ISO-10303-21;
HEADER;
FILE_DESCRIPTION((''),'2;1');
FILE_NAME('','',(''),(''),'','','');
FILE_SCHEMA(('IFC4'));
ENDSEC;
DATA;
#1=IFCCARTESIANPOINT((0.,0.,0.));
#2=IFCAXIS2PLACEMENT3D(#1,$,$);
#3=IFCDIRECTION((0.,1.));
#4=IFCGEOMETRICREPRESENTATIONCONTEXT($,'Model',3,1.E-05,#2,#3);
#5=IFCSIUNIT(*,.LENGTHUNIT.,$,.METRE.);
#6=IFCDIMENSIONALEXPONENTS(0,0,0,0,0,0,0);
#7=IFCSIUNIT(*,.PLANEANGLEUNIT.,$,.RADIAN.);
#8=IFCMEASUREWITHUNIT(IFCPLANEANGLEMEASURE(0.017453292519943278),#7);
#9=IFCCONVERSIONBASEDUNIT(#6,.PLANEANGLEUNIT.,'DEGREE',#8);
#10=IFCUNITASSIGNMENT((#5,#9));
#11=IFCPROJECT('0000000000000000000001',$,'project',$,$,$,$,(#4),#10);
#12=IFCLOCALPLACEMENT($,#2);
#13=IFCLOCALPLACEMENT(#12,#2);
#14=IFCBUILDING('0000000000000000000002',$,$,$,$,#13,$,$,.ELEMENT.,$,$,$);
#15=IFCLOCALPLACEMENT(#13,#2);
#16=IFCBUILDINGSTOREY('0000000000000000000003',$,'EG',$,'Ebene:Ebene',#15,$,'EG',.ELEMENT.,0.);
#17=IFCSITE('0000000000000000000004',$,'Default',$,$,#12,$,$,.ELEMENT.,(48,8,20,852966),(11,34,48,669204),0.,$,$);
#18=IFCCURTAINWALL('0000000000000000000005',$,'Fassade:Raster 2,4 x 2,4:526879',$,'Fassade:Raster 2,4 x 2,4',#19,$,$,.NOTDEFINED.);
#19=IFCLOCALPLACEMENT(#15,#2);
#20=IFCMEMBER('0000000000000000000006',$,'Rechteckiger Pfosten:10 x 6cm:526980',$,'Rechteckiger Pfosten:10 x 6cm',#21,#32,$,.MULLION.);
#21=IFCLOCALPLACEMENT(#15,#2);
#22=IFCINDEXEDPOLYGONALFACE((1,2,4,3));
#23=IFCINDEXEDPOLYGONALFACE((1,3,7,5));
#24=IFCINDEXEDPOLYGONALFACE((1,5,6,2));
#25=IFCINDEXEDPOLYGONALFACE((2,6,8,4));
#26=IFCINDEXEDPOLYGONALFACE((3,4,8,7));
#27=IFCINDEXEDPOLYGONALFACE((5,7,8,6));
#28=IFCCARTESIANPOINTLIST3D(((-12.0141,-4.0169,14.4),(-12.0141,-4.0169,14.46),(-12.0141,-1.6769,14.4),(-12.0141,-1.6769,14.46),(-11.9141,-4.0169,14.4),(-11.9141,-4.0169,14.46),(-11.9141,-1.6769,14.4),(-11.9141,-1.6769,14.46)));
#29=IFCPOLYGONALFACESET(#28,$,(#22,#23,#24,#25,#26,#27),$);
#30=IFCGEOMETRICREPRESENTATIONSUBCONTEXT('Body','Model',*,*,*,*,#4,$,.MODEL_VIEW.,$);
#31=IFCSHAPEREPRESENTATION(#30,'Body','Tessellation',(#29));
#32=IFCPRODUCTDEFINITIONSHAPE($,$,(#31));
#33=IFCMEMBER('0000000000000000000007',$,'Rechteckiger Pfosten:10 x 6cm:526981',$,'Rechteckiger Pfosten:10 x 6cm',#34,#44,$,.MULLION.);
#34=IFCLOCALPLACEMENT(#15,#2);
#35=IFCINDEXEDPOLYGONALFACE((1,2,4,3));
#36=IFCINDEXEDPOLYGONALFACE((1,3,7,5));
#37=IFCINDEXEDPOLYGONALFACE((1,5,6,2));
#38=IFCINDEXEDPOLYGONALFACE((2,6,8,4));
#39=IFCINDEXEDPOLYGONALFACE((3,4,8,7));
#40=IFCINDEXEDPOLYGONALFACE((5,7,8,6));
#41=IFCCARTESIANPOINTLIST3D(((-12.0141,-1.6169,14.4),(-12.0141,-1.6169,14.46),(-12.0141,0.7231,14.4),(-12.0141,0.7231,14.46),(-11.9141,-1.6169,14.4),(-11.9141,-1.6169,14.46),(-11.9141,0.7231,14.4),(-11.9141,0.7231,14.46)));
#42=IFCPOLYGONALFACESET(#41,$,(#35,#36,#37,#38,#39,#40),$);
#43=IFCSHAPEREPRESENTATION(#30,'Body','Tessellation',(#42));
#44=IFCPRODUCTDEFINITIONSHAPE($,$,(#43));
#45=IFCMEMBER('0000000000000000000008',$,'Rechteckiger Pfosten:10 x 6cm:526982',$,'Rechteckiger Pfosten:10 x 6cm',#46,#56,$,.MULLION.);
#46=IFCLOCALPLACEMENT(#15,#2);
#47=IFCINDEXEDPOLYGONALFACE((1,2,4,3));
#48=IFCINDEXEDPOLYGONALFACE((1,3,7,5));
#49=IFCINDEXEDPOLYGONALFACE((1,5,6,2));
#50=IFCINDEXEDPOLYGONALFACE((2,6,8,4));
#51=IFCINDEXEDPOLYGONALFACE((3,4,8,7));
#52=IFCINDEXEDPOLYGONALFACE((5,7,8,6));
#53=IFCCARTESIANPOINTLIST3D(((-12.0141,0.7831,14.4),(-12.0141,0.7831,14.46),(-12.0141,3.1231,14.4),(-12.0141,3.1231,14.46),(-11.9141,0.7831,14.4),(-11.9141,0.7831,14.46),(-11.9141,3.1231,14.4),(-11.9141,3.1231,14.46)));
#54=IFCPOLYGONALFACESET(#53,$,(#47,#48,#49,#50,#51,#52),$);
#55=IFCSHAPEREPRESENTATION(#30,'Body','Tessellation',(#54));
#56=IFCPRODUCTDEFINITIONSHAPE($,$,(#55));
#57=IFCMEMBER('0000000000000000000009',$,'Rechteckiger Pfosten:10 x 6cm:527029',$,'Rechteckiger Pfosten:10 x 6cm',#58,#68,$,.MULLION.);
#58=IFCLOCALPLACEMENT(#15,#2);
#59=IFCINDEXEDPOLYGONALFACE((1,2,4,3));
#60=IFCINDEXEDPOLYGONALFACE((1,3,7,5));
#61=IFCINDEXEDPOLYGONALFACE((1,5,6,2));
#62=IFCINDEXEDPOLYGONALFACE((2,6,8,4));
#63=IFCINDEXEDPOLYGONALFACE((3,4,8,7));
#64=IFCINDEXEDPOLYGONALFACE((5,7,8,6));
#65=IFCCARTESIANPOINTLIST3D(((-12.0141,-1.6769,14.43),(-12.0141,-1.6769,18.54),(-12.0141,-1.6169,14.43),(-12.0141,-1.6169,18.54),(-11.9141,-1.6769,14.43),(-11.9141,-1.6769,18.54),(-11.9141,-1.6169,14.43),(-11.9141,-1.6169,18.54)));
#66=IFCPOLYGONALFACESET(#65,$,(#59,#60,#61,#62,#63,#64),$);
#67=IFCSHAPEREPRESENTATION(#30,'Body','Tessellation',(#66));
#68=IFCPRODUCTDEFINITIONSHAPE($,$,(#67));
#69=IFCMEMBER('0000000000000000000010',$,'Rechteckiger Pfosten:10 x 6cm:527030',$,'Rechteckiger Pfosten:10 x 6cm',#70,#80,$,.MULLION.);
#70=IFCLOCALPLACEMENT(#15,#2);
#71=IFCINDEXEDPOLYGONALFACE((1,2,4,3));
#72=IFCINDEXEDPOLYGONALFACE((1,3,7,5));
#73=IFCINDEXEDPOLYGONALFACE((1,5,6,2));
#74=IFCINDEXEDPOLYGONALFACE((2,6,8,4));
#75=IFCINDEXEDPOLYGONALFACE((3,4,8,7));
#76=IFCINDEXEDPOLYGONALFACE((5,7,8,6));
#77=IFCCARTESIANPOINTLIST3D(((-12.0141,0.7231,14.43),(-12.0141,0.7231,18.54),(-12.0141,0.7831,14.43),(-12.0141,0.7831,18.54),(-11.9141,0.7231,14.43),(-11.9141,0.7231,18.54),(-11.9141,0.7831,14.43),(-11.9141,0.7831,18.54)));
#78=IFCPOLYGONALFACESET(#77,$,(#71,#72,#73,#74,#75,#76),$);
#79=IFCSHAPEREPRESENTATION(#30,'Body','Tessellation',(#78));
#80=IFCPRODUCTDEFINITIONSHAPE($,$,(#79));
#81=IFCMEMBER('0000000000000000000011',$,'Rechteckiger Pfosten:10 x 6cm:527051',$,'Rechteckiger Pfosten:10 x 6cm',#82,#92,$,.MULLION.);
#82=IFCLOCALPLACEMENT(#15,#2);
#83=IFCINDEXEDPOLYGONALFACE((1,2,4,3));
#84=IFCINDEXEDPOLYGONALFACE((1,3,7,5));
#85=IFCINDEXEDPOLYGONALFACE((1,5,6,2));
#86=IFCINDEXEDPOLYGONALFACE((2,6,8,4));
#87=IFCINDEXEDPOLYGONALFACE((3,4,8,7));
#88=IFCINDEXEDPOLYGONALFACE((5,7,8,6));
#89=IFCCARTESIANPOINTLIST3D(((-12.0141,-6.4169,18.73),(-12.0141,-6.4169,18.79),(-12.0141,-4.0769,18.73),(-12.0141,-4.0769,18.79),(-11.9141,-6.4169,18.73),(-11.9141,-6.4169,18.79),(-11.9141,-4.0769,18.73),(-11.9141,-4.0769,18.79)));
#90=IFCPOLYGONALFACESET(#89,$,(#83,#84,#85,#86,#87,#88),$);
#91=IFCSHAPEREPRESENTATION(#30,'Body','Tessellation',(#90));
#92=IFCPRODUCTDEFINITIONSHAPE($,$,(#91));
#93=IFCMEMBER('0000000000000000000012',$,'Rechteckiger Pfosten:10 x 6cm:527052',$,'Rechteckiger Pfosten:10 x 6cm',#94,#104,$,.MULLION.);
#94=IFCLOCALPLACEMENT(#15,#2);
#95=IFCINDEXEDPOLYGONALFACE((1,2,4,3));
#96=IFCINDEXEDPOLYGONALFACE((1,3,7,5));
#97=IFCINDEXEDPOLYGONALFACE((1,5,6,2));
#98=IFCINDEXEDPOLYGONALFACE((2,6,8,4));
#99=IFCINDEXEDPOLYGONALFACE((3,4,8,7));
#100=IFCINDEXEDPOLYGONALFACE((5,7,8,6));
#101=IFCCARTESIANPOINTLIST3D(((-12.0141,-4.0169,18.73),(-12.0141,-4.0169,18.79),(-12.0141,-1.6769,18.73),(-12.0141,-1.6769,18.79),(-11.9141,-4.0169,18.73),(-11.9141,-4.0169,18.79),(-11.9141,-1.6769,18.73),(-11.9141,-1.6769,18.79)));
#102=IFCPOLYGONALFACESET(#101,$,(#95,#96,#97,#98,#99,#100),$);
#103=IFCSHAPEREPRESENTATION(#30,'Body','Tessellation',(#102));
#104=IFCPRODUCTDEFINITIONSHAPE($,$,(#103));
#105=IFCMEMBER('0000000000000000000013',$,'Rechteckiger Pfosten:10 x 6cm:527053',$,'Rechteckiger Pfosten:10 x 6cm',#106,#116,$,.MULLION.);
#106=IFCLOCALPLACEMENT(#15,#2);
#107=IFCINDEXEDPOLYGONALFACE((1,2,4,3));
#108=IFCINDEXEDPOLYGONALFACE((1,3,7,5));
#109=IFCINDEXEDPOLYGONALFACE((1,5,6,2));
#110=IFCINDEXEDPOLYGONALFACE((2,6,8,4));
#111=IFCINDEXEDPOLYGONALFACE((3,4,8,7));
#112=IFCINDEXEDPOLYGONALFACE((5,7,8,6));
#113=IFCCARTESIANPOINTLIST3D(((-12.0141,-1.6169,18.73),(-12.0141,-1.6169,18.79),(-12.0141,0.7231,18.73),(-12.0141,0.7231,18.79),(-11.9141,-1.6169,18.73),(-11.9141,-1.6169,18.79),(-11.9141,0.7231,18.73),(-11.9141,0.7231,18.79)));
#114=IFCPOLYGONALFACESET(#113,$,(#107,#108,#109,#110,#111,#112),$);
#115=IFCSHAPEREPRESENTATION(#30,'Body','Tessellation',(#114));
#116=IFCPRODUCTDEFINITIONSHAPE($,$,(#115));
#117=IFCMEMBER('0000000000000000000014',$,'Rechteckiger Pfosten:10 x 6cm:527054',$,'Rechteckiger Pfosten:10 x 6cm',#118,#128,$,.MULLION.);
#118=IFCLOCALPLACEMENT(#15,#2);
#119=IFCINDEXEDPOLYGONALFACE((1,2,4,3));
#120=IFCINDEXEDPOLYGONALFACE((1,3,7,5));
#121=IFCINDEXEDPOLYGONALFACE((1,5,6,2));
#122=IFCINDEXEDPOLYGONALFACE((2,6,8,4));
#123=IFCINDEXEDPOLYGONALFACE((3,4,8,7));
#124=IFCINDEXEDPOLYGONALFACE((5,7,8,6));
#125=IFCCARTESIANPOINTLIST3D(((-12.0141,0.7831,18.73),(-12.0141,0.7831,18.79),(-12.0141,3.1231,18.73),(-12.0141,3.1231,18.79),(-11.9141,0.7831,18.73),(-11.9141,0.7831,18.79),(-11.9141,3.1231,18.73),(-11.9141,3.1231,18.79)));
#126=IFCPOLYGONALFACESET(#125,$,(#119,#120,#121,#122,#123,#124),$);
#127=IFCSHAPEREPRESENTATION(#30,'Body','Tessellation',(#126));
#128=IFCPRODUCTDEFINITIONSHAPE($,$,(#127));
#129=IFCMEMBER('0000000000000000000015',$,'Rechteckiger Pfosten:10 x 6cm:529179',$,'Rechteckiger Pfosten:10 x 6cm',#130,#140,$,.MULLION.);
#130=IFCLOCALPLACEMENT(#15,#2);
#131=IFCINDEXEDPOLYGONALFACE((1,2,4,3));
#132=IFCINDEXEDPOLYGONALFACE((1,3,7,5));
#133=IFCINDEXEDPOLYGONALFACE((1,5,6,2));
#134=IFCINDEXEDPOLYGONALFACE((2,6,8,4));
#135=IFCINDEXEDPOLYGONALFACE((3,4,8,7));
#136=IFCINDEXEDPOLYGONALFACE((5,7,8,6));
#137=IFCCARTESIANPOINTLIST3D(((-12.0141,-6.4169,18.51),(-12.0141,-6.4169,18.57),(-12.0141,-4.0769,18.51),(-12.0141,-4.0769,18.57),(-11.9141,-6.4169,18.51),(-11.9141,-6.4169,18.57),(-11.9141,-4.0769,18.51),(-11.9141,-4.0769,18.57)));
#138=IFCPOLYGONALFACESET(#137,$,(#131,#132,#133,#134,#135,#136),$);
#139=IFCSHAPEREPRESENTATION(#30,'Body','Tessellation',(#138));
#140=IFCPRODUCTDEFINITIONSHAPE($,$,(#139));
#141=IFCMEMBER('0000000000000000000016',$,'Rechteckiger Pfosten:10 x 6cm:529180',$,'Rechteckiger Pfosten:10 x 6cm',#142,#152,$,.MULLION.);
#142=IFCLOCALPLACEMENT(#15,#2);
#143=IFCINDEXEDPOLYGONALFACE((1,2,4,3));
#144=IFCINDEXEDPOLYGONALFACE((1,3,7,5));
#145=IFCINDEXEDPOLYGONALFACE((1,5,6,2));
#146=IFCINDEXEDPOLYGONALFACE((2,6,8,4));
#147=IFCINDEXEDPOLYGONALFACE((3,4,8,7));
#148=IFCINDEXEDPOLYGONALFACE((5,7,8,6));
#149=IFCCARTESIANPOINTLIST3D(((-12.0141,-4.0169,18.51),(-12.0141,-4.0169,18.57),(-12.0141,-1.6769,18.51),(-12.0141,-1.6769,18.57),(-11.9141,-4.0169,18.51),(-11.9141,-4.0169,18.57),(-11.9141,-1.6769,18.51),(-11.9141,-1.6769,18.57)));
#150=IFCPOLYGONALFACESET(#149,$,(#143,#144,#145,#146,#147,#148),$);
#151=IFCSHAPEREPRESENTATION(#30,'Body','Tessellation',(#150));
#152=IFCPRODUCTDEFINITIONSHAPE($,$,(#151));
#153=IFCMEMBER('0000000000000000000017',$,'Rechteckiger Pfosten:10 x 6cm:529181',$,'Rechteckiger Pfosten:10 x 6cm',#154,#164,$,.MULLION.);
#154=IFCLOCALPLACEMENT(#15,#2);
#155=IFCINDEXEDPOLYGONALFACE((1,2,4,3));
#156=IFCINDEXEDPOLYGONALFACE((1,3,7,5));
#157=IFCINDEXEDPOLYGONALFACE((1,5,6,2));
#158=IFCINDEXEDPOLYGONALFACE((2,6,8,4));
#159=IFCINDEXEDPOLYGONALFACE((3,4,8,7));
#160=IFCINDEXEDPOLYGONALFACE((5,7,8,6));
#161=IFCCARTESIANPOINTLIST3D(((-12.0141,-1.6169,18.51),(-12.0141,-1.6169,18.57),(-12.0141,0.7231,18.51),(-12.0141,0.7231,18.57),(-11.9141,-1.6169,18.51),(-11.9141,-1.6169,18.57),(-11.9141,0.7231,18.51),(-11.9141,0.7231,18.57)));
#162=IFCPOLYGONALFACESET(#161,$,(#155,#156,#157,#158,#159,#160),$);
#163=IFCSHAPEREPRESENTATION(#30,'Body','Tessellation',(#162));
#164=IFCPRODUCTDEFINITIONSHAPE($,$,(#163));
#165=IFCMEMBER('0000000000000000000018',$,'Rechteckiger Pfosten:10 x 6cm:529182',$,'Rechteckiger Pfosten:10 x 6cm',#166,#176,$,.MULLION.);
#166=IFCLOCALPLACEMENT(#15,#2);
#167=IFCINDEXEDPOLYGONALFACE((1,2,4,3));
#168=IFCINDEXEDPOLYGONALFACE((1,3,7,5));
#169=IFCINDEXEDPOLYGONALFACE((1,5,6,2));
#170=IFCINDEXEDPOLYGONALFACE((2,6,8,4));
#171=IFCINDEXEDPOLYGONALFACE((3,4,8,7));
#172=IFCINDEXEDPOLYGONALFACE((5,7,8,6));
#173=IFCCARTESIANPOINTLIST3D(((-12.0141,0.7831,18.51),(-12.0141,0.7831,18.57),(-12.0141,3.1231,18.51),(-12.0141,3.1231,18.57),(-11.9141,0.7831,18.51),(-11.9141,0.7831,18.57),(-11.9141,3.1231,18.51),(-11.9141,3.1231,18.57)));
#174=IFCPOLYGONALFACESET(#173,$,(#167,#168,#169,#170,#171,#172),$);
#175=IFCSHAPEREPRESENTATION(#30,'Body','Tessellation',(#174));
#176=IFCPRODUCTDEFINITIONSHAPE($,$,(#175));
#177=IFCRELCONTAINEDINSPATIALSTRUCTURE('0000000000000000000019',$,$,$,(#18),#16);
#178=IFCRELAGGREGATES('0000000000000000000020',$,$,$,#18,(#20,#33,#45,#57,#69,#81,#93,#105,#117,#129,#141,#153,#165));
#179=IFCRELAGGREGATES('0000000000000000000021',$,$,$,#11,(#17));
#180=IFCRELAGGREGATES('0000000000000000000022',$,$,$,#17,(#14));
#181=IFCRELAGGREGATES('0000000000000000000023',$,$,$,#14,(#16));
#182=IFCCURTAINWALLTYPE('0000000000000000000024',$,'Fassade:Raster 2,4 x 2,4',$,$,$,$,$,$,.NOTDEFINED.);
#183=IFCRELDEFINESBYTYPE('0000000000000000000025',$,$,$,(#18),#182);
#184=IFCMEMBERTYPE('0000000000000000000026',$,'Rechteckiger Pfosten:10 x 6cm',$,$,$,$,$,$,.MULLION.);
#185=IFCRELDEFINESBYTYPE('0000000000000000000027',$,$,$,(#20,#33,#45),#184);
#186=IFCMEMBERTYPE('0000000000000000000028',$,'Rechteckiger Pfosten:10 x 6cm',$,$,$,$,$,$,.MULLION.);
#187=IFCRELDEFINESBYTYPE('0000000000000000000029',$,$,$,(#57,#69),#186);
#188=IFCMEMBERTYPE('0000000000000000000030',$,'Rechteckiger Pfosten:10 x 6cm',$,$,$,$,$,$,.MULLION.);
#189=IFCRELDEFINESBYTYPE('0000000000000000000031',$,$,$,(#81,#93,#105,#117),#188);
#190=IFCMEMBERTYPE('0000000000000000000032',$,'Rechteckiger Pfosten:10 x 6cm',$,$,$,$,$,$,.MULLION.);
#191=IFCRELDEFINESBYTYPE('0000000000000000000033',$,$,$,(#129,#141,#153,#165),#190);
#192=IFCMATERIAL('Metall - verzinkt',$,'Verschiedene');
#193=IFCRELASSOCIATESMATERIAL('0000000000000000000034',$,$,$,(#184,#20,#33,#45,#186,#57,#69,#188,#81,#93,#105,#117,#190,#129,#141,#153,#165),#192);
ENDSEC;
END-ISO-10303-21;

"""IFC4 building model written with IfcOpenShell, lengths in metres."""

from ifc_helpers import new_model, entity, si_unit, converted_unit, direction, frame, origin, place, context, subcontext, project, spatial, indexed_curve, outline, extrude, source, transform, mapped, material, type_object, type_shapes, element, aggregate, save


model = new_model("IFC4")

# Units and contexts
model_context = context("Model", 3, precision=1e-05, world=origin(), true_north=direction((0.0, 1.0)))
body_context = subcontext(model_context, "Body", "Model", "MODEL_VIEW")
ifc_project = project(units=[si_unit("LENGTHUNIT", "METRE"), converted_unit("PLANEANGLEUNIT", "DEGREE", entity("IfcPlaneAngleMeasure", 0.017453292519943278), si_unit("PLANEANGLEUNIT", "RADIAN"), dimensions=[0, 0, 0, 0, 0, 0, 0])], contexts=[model_context])

# Site, building, storey
site_placement = place(None, origin())
site = spatial("IfcSite", under=ifc_project, at=site_placement, Name="Default", CompositionType="ELEMENT", RefLatitude=(48, 8, 20, 852966), RefLongitude=(11, 34, 48, 669204), RefElevation=0.0)
building_placement = place(site_placement, origin())
building = spatial("IfcBuilding", under=site, at=building_placement, CompositionType="ELEMENT")
storey_placement = place(building_placement, origin())
storey = spatial("IfcBuildingStorey", under=building, at=storey_placement, Name="EG", ObjectType="Ebene:Ebene", LongName="EG", CompositionType="ELEMENT", Elevation=0.0)

# Curtain wall, members
curtain_wall_type = type_object("IfcCurtainWallType", Name="Fassade:Raster 2,4 x 2,4", PredefinedType="NOTDEFINED")
curtain_wall_placement = place(storey_placement, origin())
curtain_wall = element("IfcCurtainWall", 1, at=curtain_wall_placement, inside=storey, type_object=curtain_wall_type, Name="Fassade:Raster 2,4 x 2,4:526879", ObjectType="Fassade:Raster 2,4 x 2,4", PredefinedType="NOTDEFINED")
ifc_material_1 = material(Name="Metall - verzinkt", Category="Verschiedene")
member_type_1 = type_object("IfcMemberType", Name="Rechteckiger Pfosten:10 x 6cm", PredefinedType="MULLION", material=ifc_material_1)
shared_shape_1 = source(origin(), body_context, "Body", "SweptSolid", [
    extrude(outline(indexed_curve([(-0.03, -0.05), (0.03, -0.05), (0.03, 0.05), (-0.03, 0.05), (-0.03, -0.05)], self_intersect=False)), frame((0.0, 0.0, -2.34), z_axis=(0.0, 0.0, 1.0), x_axis=(-1.0, 0.0, 0.0)), (0.0, 0.0, 1.0), 2.34),
])
type_shapes(member_type_1, [shared_shape_1])
member_1_placement = place(curtain_wall_placement, frame((-11.9641, -1.6769, 14.43), z_axis=(0.0, 1.0, 0.0), x_axis=(0.0, 0.0, 1.0)))
member_1 = element("IfcMember", 2, at=member_1_placement, type_object=member_type_1, material=ifc_material_1, Name="Rechteckiger Pfosten:10 x 6cm:526980", ObjectType="Rechteckiger Pfosten:10 x 6cm", PredefinedType="MULLION", context=body_context, shape_type="MappedRepresentation", body=[
    mapped(shared_shape_1, transform((0.0, 0.0, 0.0), scale=1.0)),
])
member_2_placement = place(curtain_wall_placement, frame((-11.9641, 0.7231, 14.43), z_axis=(0.0, 1.0, 0.0), x_axis=(0.0, 0.0, 1.0)))
member_2 = element("IfcMember", 3, at=member_2_placement, type_object=member_type_1, material=ifc_material_1, Name="Rechteckiger Pfosten:10 x 6cm:526981", ObjectType="Rechteckiger Pfosten:10 x 6cm", PredefinedType="MULLION", context=body_context, shape_type="MappedRepresentation", body=[
    mapped(shared_shape_1, transform((0.0, 0.0, 0.0), scale=1.0)),
])
member_3_placement = place(curtain_wall_placement, frame((-11.9641, 3.1231, 14.43), z_axis=(0.0, 1.0, 0.0), x_axis=(0.0, 0.0, 1.0)))
member_3 = element("IfcMember", 4, at=member_3_placement, type_object=member_type_1, material=ifc_material_1, Name="Rechteckiger Pfosten:10 x 6cm:526982", ObjectType="Rechteckiger Pfosten:10 x 6cm", PredefinedType="MULLION", context=body_context, shape_type="MappedRepresentation", body=[
    mapped(shared_shape_1, transform((0.0, 0.0, 0.0), scale=1.0)),
])
member_type_2 = type_object("IfcMemberType", Name="Rechteckiger Pfosten:10 x 6cm", PredefinedType="MULLION", material=ifc_material_1)
shared_shape_2 = source(origin(), body_context, "Body", "SweptSolid", [
    extrude(outline(indexed_curve([(-0.03, -0.05), (0.03, -0.05), (0.03, 0.05), (-0.03, 0.05), (-0.03, -0.05)], self_intersect=False)), frame((0.0, 0.0, -4.11), z_axis=(0.0, 0.0, 1.0), x_axis=(-1.0, 0.0, 0.0)), (0.0, 0.0, 1.0), 4.11),
])
type_shapes(member_type_2, [shared_shape_2])
member_4_placement = place(curtain_wall_placement, frame((-11.9641, -1.6469, 14.43), z_axis=(0.0, 0.0, -1.0), x_axis=(0.0, 1.0, 0.0)))
member_4 = element("IfcMember", 5, at=member_4_placement, type_object=member_type_2, material=ifc_material_1, Name="Rechteckiger Pfosten:10 x 6cm:527029", ObjectType="Rechteckiger Pfosten:10 x 6cm", PredefinedType="MULLION", context=body_context, shape_type="MappedRepresentation", body=[
    mapped(shared_shape_2, transform((0.0, 0.0, 0.0), scale=1.0)),
])
member_5_placement = place(curtain_wall_placement, frame((-11.9641, 0.7531, 14.43), z_axis=(0.0, 0.0, -1.0), x_axis=(0.0, 1.0, 0.0)))
member_5 = element("IfcMember", 6, at=member_5_placement, type_object=member_type_2, material=ifc_material_1, Name="Rechteckiger Pfosten:10 x 6cm:527030", ObjectType="Rechteckiger Pfosten:10 x 6cm", PredefinedType="MULLION", context=body_context, shape_type="MappedRepresentation", body=[
    mapped(shared_shape_2, transform((0.0, 0.0, 0.0), scale=1.0)),
])
member_type_3 = type_object("IfcMemberType", Name="Rechteckiger Pfosten:10 x 6cm", PredefinedType="MULLION", material=ifc_material_1)
shared_shape_3 = source(origin(), body_context, "Body", "SweptSolid", [
    extrude(outline(indexed_curve([(-0.03, -0.05), (0.03, -0.05), (0.03, 0.05), (-0.03, 0.05), (-0.03, -0.05)], self_intersect=False)), frame((-0.03, 0.0, -2.34), z_axis=(0.0, 0.0, 1.0), x_axis=(-1.0, 0.0, 0.0)), (0.0, 0.0, 1.0), 2.34),
])
type_shapes(member_type_3, [shared_shape_3])
member_6_placement = place(curtain_wall_placement, frame((-11.9641, -4.0769, 18.79), z_axis=(0.0, 1.0, 0.0), x_axis=(0.0, 0.0, 1.0)))
member_6 = element("IfcMember", 7, at=member_6_placement, type_object=member_type_3, material=ifc_material_1, Name="Rechteckiger Pfosten:10 x 6cm:527051", ObjectType="Rechteckiger Pfosten:10 x 6cm", PredefinedType="MULLION", context=body_context, shape_type="MappedRepresentation", body=[
    mapped(shared_shape_3, transform((0.0, 0.0, 0.0), scale=1.0)),
])
member_7_placement = place(curtain_wall_placement, frame((-11.9641, -1.6769, 18.79), z_axis=(0.0, 1.0, 0.0), x_axis=(0.0, 0.0, 1.0)))
member_7 = element("IfcMember", 8, at=member_7_placement, type_object=member_type_3, material=ifc_material_1, Name="Rechteckiger Pfosten:10 x 6cm:527052", ObjectType="Rechteckiger Pfosten:10 x 6cm", PredefinedType="MULLION", context=body_context, shape_type="MappedRepresentation", body=[
    mapped(shared_shape_3, transform((0.0, 0.0, 0.0), scale=1.0)),
])
member_8_placement = place(curtain_wall_placement, frame((-11.9641, 0.7231, 18.79), z_axis=(0.0, 1.0, 0.0), x_axis=(0.0, 0.0, 1.0)))
member_8 = element("IfcMember", 9, at=member_8_placement, type_object=member_type_3, material=ifc_material_1, Name="Rechteckiger Pfosten:10 x 6cm:527053", ObjectType="Rechteckiger Pfosten:10 x 6cm", PredefinedType="MULLION", context=body_context, shape_type="MappedRepresentation", body=[
    mapped(shared_shape_3, transform((0.0, 0.0, 0.0), scale=1.0)),
])
member_9_placement = place(curtain_wall_placement, frame((-11.9641, 3.1231, 18.79), z_axis=(0.0, 1.0, 0.0), x_axis=(0.0, 0.0, 1.0)))
member_9 = element("IfcMember", 10, at=member_9_placement, type_object=member_type_3, material=ifc_material_1, Name="Rechteckiger Pfosten:10 x 6cm:527054", ObjectType="Rechteckiger Pfosten:10 x 6cm", PredefinedType="MULLION", context=body_context, shape_type="MappedRepresentation", body=[
    mapped(shared_shape_3, transform((0.0, 0.0, 0.0), scale=1.0)),
])
member_type_4 = type_object("IfcMemberType", Name="Rechteckiger Pfosten:10 x 6cm", PredefinedType="MULLION", material=ifc_material_1)
shared_shape_4 = source(origin(), body_context, "Body", "SweptSolid", [
    extrude(outline(indexed_curve([(-0.03, -0.05), (0.03, -0.05), (0.03, 0.05), (-0.03, 0.05), (-0.03, -0.05)], self_intersect=False)), frame((0.0, 0.0, -2.34), z_axis=(0.0, 0.0, 1.0), x_axis=(-1.0, 0.0, 0.0)), (0.0, 0.0, 1.0), 2.34),
])
type_shapes(member_type_4, [shared_shape_4])
member_10_placement = place(curtain_wall_placement, frame((-11.9641, -4.0769, 18.54), z_axis=(0.0, 1.0, 0.0), x_axis=(0.0, 0.0, 1.0)))
member_10 = element("IfcMember", 11, at=member_10_placement, type_object=member_type_4, material=ifc_material_1, Name="Rechteckiger Pfosten:10 x 6cm:529179", ObjectType="Rechteckiger Pfosten:10 x 6cm", PredefinedType="MULLION", context=body_context, shape_type="MappedRepresentation", body=[
    mapped(shared_shape_4, transform((0.0, 0.0, 0.0), scale=1.0)),
])
member_11_placement = place(curtain_wall_placement, frame((-11.9641, -1.6769, 18.54), z_axis=(0.0, 1.0, 0.0), x_axis=(0.0, 0.0, 1.0)))
member_11 = element("IfcMember", 12, at=member_11_placement, type_object=member_type_4, material=ifc_material_1, Name="Rechteckiger Pfosten:10 x 6cm:529180", ObjectType="Rechteckiger Pfosten:10 x 6cm", PredefinedType="MULLION", context=body_context, shape_type="MappedRepresentation", body=[
    mapped(shared_shape_4, transform((0.0, 0.0, 0.0), scale=1.0)),
])
member_12_placement = place(curtain_wall_placement, frame((-11.9641, 0.7231, 18.54), z_axis=(0.0, 1.0, 0.0), x_axis=(0.0, 0.0, 1.0)))
member_12 = element("IfcMember", 13, at=member_12_placement, type_object=member_type_4, material=ifc_material_1, Name="Rechteckiger Pfosten:10 x 6cm:529181", ObjectType="Rechteckiger Pfosten:10 x 6cm", PredefinedType="MULLION", context=body_context, shape_type="MappedRepresentation", body=[
    mapped(shared_shape_4, transform((0.0, 0.0, 0.0), scale=1.0)),
])
member_13_placement = place(curtain_wall_placement, frame((-11.9641, 3.1231, 18.54), z_axis=(0.0, 1.0, 0.0), x_axis=(0.0, 0.0, 1.0)))
member_13 = element("IfcMember", 14, at=member_13_placement, type_object=member_type_4, material=ifc_material_1, Name="Rechteckiger Pfosten:10 x 6cm:529182", ObjectType="Rechteckiger Pfosten:10 x 6cm", PredefinedType="MULLION", context=body_context, shape_type="MappedRepresentation", body=[
    mapped(shared_shape_4, transform((0.0, 0.0, 0.0), scale=1.0)),
])
aggregate(curtain_wall, [member_1, member_2, member_3, member_4, member_5, member_6, member_7, member_8, member_9, member_10, member_11, member_12, member_13])

save(model, "model.ifc")
